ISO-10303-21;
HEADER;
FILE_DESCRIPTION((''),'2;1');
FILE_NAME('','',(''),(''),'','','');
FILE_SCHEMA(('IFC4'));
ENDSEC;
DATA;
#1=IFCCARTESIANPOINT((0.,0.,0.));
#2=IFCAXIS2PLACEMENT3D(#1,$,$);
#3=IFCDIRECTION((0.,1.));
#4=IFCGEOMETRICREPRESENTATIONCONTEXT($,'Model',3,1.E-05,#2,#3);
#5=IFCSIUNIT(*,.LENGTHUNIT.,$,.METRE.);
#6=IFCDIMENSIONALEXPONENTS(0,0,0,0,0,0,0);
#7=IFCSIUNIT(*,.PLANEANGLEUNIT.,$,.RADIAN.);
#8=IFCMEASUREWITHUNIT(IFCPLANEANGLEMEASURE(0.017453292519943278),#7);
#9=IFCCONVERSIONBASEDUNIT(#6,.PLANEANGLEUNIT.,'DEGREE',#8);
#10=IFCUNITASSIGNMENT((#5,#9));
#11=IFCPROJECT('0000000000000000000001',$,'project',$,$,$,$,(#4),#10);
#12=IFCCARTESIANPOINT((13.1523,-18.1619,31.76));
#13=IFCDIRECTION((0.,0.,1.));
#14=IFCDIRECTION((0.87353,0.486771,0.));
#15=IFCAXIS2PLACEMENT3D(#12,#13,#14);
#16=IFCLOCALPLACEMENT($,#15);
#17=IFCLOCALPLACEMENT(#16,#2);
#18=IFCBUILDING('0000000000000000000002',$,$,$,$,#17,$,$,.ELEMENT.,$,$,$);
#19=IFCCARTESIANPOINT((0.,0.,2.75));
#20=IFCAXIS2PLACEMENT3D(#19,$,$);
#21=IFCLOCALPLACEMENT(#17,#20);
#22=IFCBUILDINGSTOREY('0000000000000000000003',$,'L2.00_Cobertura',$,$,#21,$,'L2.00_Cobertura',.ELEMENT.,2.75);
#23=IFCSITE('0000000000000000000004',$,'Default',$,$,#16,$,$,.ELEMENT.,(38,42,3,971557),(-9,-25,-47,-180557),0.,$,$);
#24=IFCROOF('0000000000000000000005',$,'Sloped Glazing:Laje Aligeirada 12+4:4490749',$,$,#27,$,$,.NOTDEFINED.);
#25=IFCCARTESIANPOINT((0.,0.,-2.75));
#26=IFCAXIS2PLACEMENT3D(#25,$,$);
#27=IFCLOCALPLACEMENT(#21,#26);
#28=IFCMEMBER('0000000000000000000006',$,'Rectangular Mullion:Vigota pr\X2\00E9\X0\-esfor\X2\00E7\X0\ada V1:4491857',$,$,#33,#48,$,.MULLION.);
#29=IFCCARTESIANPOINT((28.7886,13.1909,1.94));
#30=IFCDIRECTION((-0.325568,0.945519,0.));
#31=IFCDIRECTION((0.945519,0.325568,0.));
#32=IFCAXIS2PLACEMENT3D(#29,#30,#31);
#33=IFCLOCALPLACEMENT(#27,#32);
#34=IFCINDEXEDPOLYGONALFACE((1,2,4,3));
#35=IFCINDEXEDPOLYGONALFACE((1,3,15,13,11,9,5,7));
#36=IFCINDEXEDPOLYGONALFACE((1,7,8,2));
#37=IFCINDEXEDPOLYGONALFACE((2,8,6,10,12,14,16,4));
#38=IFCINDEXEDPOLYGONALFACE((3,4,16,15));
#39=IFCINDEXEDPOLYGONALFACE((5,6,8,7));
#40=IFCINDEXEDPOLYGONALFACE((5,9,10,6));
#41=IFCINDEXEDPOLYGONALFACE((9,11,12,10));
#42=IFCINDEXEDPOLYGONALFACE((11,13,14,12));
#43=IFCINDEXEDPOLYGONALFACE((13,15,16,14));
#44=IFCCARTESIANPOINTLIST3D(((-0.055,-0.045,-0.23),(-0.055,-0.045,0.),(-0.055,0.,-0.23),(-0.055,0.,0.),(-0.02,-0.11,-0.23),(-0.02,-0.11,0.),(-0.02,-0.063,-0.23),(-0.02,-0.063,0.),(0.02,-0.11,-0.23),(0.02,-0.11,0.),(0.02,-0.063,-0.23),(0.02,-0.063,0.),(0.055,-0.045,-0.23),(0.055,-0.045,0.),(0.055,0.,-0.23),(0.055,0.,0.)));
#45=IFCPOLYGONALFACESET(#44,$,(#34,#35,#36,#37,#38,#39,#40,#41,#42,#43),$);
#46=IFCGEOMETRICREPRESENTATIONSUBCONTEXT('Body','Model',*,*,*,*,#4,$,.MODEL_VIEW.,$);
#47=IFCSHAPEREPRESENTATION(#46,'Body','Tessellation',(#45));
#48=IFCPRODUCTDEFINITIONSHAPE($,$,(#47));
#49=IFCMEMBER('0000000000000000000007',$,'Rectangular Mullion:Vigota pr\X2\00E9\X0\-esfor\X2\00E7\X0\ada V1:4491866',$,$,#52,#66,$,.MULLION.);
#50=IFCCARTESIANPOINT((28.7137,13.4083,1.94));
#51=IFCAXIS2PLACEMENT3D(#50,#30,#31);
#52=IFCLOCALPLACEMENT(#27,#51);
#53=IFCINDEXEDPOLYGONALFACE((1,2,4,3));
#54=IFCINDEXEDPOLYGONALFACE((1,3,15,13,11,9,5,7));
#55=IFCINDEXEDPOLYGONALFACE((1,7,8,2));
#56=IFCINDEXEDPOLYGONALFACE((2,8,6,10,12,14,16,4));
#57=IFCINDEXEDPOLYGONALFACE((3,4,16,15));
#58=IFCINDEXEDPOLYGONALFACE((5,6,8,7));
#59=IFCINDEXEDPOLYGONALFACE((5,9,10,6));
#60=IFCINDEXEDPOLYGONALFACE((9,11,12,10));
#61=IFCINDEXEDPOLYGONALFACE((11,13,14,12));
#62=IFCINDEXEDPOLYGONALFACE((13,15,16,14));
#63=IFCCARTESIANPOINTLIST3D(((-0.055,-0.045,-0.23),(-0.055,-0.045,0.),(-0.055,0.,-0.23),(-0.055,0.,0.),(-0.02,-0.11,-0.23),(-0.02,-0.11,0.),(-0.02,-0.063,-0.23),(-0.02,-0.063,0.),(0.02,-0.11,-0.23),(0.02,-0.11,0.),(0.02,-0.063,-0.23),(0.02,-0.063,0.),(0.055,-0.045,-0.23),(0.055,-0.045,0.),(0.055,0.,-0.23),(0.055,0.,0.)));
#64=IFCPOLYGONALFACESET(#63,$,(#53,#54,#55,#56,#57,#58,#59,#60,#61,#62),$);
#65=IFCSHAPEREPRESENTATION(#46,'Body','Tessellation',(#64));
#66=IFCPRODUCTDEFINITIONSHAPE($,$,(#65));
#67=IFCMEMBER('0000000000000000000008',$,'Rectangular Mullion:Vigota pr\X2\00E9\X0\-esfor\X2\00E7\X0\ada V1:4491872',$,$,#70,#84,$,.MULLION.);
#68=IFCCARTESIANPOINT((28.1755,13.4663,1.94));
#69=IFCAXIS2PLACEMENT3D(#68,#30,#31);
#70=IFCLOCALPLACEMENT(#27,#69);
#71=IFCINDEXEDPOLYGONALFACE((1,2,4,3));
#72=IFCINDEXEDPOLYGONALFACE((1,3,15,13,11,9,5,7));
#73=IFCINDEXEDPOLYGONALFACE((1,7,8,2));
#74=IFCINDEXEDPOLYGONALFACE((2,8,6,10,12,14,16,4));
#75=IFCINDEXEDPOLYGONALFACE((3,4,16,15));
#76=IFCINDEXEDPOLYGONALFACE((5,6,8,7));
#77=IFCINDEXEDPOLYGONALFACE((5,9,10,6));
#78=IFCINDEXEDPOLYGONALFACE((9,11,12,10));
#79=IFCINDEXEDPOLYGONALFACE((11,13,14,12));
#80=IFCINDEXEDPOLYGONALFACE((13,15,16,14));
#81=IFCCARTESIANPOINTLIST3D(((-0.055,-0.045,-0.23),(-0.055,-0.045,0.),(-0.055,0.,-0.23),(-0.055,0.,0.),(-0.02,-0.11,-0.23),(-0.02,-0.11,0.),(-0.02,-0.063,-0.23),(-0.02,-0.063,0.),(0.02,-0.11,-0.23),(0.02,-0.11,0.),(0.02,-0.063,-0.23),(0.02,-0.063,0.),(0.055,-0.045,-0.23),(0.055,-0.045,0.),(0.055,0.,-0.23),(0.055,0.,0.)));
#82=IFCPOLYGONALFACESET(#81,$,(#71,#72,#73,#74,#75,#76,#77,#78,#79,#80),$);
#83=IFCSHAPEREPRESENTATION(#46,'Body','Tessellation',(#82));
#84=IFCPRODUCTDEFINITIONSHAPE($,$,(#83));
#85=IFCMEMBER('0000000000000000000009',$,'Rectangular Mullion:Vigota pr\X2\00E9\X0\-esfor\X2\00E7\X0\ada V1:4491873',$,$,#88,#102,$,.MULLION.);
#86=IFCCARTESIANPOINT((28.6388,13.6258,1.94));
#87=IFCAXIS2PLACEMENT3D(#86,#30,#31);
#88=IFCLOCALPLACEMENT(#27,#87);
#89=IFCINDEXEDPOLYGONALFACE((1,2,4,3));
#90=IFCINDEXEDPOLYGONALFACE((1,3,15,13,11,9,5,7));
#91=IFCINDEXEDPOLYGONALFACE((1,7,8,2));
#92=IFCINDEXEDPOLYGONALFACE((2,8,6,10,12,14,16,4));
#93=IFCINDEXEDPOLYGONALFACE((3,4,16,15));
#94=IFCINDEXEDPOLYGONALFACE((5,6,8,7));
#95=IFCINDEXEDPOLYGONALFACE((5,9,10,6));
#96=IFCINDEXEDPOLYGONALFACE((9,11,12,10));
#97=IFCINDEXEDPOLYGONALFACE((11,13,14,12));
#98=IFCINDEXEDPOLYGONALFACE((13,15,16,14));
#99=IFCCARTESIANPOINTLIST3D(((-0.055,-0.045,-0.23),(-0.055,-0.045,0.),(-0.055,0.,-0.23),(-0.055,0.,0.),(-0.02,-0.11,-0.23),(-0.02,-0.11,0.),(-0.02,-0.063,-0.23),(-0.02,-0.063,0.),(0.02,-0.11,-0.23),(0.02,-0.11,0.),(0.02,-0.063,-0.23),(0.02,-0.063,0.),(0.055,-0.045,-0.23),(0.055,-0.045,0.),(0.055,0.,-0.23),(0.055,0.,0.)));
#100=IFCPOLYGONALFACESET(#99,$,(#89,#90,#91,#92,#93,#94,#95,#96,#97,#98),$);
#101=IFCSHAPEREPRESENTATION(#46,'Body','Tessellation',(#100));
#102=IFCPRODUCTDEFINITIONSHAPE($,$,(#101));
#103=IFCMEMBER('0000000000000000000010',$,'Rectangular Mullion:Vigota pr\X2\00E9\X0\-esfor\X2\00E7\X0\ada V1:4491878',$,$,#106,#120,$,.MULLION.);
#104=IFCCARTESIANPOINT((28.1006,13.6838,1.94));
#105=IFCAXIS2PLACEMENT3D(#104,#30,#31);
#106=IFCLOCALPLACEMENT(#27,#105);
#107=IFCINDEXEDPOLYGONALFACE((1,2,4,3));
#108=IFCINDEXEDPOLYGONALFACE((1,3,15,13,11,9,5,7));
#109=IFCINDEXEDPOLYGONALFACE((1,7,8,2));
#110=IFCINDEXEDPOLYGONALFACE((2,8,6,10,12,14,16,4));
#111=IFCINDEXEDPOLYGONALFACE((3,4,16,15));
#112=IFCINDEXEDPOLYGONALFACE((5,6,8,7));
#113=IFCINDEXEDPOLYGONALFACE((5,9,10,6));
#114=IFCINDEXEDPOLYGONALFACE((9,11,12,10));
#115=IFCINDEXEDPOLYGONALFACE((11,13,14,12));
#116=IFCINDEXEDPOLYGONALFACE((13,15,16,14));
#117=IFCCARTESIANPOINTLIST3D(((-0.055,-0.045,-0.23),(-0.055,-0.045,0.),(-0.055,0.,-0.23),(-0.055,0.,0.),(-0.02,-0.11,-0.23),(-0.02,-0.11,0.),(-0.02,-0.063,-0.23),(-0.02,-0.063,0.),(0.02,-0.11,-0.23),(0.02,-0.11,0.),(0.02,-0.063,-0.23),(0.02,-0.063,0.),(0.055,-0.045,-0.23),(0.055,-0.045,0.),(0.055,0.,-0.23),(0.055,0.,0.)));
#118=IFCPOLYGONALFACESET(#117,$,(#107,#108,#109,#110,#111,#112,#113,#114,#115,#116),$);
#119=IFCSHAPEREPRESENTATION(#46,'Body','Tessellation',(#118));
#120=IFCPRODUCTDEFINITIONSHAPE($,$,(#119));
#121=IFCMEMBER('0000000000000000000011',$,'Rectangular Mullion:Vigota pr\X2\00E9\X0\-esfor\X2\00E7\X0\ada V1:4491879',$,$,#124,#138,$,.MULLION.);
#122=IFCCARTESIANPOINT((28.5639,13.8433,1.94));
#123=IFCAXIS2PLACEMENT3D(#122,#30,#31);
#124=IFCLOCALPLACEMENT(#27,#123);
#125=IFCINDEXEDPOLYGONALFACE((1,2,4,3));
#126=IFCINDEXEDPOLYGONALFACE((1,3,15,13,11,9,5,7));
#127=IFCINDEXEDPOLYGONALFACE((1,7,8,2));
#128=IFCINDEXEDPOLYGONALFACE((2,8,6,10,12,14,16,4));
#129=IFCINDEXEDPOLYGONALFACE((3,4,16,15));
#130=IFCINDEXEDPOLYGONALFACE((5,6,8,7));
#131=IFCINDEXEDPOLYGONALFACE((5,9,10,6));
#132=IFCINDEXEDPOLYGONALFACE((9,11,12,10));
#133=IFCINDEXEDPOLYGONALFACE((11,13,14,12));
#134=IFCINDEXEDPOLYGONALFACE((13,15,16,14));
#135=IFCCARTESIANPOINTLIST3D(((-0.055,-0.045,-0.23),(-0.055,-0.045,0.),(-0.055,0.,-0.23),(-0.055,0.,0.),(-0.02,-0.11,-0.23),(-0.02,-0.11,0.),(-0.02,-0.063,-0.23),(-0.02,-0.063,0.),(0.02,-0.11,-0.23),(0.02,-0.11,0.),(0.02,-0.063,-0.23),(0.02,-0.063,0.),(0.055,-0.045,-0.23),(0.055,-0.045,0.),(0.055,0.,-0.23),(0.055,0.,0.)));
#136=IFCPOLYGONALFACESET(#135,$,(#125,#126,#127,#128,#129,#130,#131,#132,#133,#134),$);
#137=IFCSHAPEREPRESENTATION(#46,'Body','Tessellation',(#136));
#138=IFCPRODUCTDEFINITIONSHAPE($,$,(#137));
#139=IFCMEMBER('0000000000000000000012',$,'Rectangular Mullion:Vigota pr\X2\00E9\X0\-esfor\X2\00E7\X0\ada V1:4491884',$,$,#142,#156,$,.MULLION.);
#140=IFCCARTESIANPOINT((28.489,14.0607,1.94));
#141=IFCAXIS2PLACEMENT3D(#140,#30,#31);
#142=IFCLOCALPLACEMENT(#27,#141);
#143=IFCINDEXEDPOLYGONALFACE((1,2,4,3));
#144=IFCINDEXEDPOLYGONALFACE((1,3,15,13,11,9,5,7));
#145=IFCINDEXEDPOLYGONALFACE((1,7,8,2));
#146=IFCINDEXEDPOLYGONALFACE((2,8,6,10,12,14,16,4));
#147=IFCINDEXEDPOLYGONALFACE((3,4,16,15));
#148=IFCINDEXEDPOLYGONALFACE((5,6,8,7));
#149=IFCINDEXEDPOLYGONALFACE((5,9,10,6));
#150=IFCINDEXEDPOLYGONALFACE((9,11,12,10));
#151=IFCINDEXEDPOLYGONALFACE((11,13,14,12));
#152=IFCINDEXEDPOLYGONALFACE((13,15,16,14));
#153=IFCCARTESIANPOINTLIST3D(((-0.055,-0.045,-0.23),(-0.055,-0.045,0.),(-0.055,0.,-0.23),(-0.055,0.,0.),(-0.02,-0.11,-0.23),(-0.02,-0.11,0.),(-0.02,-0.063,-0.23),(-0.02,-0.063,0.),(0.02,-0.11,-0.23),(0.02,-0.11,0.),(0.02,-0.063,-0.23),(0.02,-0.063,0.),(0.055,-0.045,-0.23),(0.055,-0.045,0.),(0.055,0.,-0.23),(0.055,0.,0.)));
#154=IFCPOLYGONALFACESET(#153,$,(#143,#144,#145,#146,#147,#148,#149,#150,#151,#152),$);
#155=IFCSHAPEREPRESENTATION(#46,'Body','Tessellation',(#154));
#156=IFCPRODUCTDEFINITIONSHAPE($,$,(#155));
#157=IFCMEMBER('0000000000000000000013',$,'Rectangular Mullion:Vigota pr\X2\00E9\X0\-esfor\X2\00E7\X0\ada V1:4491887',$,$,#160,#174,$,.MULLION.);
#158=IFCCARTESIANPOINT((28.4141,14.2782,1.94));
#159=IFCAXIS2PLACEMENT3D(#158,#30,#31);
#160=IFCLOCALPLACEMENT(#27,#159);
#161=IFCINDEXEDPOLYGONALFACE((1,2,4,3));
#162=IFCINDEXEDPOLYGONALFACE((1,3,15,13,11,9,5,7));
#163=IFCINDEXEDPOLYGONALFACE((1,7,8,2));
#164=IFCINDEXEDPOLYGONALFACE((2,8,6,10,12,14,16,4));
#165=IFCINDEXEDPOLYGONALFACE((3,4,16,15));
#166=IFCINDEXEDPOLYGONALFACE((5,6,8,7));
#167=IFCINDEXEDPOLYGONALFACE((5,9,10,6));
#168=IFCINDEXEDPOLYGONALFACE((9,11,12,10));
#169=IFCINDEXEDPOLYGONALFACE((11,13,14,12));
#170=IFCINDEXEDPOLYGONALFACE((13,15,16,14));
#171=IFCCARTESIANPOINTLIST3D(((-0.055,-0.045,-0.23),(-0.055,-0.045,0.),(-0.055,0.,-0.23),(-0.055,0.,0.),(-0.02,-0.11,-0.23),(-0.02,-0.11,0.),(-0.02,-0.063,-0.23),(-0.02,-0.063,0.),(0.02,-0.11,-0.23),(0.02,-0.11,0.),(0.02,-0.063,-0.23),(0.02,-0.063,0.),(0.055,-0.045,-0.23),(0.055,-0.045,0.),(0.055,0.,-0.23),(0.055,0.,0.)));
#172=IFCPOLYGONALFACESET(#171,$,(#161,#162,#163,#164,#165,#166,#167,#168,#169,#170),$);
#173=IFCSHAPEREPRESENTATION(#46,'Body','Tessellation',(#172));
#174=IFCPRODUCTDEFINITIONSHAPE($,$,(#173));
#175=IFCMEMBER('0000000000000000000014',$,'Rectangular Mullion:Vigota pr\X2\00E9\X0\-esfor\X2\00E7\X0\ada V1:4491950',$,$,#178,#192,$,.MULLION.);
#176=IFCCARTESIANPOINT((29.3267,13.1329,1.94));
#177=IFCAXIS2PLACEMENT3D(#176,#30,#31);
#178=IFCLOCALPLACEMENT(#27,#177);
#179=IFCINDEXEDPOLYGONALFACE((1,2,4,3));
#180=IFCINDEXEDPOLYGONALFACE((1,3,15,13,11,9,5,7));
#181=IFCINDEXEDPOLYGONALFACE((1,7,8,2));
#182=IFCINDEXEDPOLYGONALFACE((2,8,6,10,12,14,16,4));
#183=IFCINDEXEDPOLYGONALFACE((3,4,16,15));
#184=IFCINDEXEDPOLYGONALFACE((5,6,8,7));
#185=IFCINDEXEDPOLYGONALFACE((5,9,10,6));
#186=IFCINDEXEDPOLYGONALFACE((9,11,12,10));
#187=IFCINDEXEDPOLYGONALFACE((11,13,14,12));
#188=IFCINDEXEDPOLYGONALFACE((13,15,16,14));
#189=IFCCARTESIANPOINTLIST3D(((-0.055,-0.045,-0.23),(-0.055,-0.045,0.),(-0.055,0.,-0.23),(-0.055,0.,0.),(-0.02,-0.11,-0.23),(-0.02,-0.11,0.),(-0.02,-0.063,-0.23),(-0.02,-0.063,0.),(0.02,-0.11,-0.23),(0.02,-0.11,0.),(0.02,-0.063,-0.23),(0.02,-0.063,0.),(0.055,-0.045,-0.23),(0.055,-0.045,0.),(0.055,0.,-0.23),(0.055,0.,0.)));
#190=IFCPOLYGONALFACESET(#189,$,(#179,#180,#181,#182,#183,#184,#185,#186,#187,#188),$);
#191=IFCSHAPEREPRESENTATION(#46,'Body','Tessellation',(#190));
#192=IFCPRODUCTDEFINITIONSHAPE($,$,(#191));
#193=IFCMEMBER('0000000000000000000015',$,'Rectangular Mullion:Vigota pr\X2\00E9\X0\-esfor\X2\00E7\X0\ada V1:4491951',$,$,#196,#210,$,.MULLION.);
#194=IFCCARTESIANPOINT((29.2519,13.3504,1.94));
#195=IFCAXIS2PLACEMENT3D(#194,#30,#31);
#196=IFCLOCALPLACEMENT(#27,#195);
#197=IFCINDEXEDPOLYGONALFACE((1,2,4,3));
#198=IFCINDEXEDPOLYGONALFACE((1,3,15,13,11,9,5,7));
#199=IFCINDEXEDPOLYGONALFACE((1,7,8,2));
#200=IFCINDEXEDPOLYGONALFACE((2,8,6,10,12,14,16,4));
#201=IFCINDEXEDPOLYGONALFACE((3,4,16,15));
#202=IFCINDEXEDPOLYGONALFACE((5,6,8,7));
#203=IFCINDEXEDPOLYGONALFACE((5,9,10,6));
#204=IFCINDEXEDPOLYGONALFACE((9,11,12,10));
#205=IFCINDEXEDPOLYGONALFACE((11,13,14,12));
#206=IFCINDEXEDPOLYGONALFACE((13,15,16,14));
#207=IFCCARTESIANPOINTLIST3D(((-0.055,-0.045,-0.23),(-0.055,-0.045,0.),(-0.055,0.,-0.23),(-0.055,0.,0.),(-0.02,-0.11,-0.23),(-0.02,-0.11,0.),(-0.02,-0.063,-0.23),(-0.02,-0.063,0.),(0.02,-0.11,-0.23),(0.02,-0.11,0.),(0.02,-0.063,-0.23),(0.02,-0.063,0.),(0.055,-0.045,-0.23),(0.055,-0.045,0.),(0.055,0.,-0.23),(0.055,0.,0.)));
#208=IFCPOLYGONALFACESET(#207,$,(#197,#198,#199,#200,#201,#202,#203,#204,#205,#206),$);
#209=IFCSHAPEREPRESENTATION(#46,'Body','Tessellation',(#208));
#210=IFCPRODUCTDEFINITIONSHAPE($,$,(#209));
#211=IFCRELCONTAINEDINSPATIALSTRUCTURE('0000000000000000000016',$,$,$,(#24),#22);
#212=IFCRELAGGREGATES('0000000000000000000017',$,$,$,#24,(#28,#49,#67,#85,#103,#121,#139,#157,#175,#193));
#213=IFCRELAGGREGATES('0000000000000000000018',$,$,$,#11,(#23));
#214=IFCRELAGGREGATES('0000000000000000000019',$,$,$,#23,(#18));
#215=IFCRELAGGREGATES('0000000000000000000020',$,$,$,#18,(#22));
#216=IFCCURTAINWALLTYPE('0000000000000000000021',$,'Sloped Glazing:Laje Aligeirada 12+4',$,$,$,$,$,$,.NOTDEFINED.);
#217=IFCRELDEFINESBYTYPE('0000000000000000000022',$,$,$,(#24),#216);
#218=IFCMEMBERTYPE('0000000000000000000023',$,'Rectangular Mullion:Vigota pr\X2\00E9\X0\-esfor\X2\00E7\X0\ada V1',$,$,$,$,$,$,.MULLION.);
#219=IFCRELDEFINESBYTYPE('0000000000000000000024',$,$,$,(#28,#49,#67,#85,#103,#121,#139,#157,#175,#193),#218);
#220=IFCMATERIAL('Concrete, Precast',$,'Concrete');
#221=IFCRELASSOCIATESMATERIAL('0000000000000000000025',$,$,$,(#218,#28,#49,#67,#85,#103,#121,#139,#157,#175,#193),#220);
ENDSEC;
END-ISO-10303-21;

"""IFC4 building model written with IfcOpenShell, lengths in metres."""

from ifc_helpers import new_model, entity, si_unit, converted_unit, direction, frame, origin, place, context, subcontext, project, spatial, indexed_curve, outline, extrude, source, transform, mapped, material, type_object, type_shapes, element, aggregate, save


model = new_model("IFC4")

# Units and contexts
model_context = context("Model", 3, precision=1e-05, world=origin(), true_north=direction((0.0, 1.0)))
body_context = subcontext(model_context, "Body", "Model", "MODEL_VIEW")
ifc_project = project(units=[si_unit("LENGTHUNIT", "METRE"), converted_unit("PLANEANGLEUNIT", "DEGREE", entity("IfcPlaneAngleMeasure", 0.017453292519943278), si_unit("PLANEANGLEUNIT", "RADIAN"), dimensions=[0, 0, 0, 0, 0, 0, 0])], contexts=[model_context])

# Site, building, storey
site_placement = place(None, frame((13.1523, -18.1619, 31.76), z_axis=(0.0, 0.0, 1.0), x_axis=(0.87353, 0.486771, 0.0)))
site = spatial("IfcSite", under=ifc_project, at=site_placement, Name="Default", CompositionType="ELEMENT", RefLatitude=(38, 42, 3, 971557), RefLongitude=(-9, -25, -47, -180557), RefElevation=0.0)
building_placement = place(site_placement, origin())
building = spatial("IfcBuilding", under=site, at=building_placement, CompositionType="ELEMENT")
storey_placement = place(building_placement, frame((0.0, 0.0, 2.75)))
storey = spatial("IfcBuildingStorey", under=building, at=storey_placement, Name="L2.00_Cobertura", LongName="L2.00_Cobertura", CompositionType="ELEMENT", Elevation=2.75)

# Roof, members
curtain_wall_type = type_object("IfcCurtainWallType", Name="Sloped Glazing:Laje Aligeirada 12+4", PredefinedType="NOTDEFINED")
roof_placement = place(storey_placement, frame((0.0, 0.0, -2.75)))
roof = element("IfcRoof", 1, at=roof_placement, inside=storey, type_object=curtain_wall_type, Name="Sloped Glazing:Laje Aligeirada 12+4:4490749", PredefinedType="NOTDEFINED")
ifc_material_1 = material(Name="Concrete, Precast", Category="Concrete")
member_type_1 = type_object("IfcMemberType", Name="Rectangular Mullion:Vigota pré-esforçada V1", PredefinedType="MULLION", material=ifc_material_1)
shared_shape_1 = source(origin(), body_context, "Body", "SweptSolid", [
    extrude(outline(indexed_curve([(-0.055, -0.0545), (0.055, -0.0545), (0.055, -0.0095), (0.02, 0.0085), (0.02, 0.0555), (-0.02, 0.0555), (-0.02, 0.0085), (-0.055, -0.0095), (-0.055, -0.0545)], self_intersect=False)), frame((0.0, -0.0545, -0.23), z_axis=(0.0, 0.0, 1.0), x_axis=(-1.0, 0.0, 0.0)), (0.0, 0.0, 1.0), 0.23),
])
type_shapes(member_type_1, [shared_shape_1])
member_1_placement = place(roof_placement, frame((28.7886, 13.1909, 1.94), z_axis=(-0.325568, 0.945519, 0.0), x_axis=(0.945519, 0.325568, 0.0)))
member_1 = element("IfcMember", 2, at=member_1_placement, type_object=member_type_1, material=ifc_material_1, Name="Rectangular Mullion:Vigota pré-esforçada V1:4491857", PredefinedType="MULLION", context=body_context, shape_type="MappedRepresentation", body=[
    mapped(shared_shape_1, transform((0.0, 0.0, 0.0), scale=1.0)),
])
member_2_placement = place(roof_placement, frame((28.7137, 13.4083, 1.94), z_axis=(-0.325568, 0.945519, 0.0), x_axis=(0.945519, 0.325568, 0.0)))
member_2 = element("IfcMember", 3, at=member_2_placement, type_object=member_type_1, material=ifc_material_1, Name="Rectangular Mullion:Vigota pré-esforçada V1:4491866", PredefinedType="MULLION", context=body_context, shape_type="MappedRepresentation", body=[
    mapped(shared_shape_1, transform((0.0, 0.0, 0.0), scale=1.0)),
])
member_3_placement = place(roof_placement, frame((28.1755, 13.4663, 1.94), z_axis=(-0.325568, 0.945519, 0.0), x_axis=(0.945519, 0.325568, 0.0)))
member_3 = element("IfcMember", 4, at=member_3_placement, type_object=member_type_1, material=ifc_material_1, Name="Rectangular Mullion:Vigota pré-esforçada V1:4491872", PredefinedType="MULLION", context=body_context, shape_type="MappedRepresentation", body=[
    mapped(shared_shape_1, transform((0.0, 0.0, 0.0), scale=1.0)),
])
member_4_placement = place(roof_placement, frame((28.6388, 13.6258, 1.94), z_axis=(-0.325568, 0.945519, 0.0), x_axis=(0.945519, 0.325568, 0.0)))
member_4 = element("IfcMember", 5, at=member_4_placement, type_object=member_type_1, material=ifc_material_1, Name="Rectangular Mullion:Vigota pré-esforçada V1:4491873", PredefinedType="MULLION", context=body_context, shape_type="MappedRepresentation", body=[
    mapped(shared_shape_1, transform((0.0, 0.0, 0.0), scale=1.0)),
])
member_5_placement = place(roof_placement, frame((28.1006, 13.6838, 1.94), z_axis=(-0.325568, 0.945519, 0.0), x_axis=(0.945519, 0.325568, 0.0)))
member_5 = element("IfcMember", 6, at=member_5_placement, type_object=member_type_1, material=ifc_material_1, Name="Rectangular Mullion:Vigota pré-esforçada V1:4491878", PredefinedType="MULLION", context=body_context, shape_type="MappedRepresentation", body=[
    mapped(shared_shape_1, transform((0.0, 0.0, 0.0), scale=1.0)),
])
member_6_placement = place(roof_placement, frame((28.5639, 13.8433, 1.94), z_axis=(-0.325568, 0.945519, 0.0), x_axis=(0.945519, 0.325568, 0.0)))
member_6 = element("IfcMember", 7, at=member_6_placement, type_object=member_type_1, material=ifc_material_1, Name="Rectangular Mullion:Vigota pré-esforçada V1:4491879", PredefinedType="MULLION", context=body_context, shape_type="MappedRepresentation", body=[
    mapped(shared_shape_1, transform((0.0, 0.0, 0.0), scale=1.0)),
])
member_7_placement = place(roof_placement, frame((28.489, 14.0607, 1.94), z_axis=(-0.325568, 0.945519, 0.0), x_axis=(0.945519, 0.325568, 0.0)))
member_7 = element("IfcMember", 8, at=member_7_placement, type_object=member_type_1, material=ifc_material_1, Name="Rectangular Mullion:Vigota pré-esforçada V1:4491884", PredefinedType="MULLION", context=body_context, shape_type="MappedRepresentation", body=[
    mapped(shared_shape_1, transform((0.0, 0.0, 0.0), scale=1.0)),
])
member_8_placement = place(roof_placement, frame((28.4141, 14.2782, 1.94), z_axis=(-0.325568, 0.945519, 0.0), x_axis=(0.945519, 0.325568, 0.0)))
member_8 = element("IfcMember", 9, at=member_8_placement, type_object=member_type_1, material=ifc_material_1, Name="Rectangular Mullion:Vigota pré-esforçada V1:4491887", PredefinedType="MULLION", context=body_context, shape_type="MappedRepresentation", body=[
    mapped(shared_shape_1, transform((0.0, 0.0, 0.0), scale=1.0)),
])
member_9_placement = place(roof_placement, frame((29.3267, 13.1329, 1.94), z_axis=(-0.325568, 0.945519, 0.0), x_axis=(0.945519, 0.325568, 0.0)))
member_9 = element("IfcMember", 10, at=member_9_placement, type_object=member_type_1, material=ifc_material_1, Name="Rectangular Mullion:Vigota pré-esforçada V1:4491950", PredefinedType="MULLION", context=body_context, shape_type="MappedRepresentation", body=[
    mapped(shared_shape_1, transform((0.0, 0.0, 0.0), scale=1.0)),
])
member_10_placement = place(roof_placement, frame((29.2519, 13.3504, 1.94), z_axis=(-0.325568, 0.945519, 0.0), x_axis=(0.945519, 0.325568, 0.0)))
member_10 = element("IfcMember", 11, at=member_10_placement, type_object=member_type_1, material=ifc_material_1, Name="Rectangular Mullion:Vigota pré-esforçada V1:4491951", PredefinedType="MULLION", context=body_context, shape_type="MappedRepresentation", body=[
    mapped(shared_shape_1, transform((0.0, 0.0, 0.0), scale=1.0)),
])
aggregate(roof, [member_1, member_2, member_3, member_4, member_5, member_6, member_7, member_8, member_9, member_10])

save(model, "model.ifc")
